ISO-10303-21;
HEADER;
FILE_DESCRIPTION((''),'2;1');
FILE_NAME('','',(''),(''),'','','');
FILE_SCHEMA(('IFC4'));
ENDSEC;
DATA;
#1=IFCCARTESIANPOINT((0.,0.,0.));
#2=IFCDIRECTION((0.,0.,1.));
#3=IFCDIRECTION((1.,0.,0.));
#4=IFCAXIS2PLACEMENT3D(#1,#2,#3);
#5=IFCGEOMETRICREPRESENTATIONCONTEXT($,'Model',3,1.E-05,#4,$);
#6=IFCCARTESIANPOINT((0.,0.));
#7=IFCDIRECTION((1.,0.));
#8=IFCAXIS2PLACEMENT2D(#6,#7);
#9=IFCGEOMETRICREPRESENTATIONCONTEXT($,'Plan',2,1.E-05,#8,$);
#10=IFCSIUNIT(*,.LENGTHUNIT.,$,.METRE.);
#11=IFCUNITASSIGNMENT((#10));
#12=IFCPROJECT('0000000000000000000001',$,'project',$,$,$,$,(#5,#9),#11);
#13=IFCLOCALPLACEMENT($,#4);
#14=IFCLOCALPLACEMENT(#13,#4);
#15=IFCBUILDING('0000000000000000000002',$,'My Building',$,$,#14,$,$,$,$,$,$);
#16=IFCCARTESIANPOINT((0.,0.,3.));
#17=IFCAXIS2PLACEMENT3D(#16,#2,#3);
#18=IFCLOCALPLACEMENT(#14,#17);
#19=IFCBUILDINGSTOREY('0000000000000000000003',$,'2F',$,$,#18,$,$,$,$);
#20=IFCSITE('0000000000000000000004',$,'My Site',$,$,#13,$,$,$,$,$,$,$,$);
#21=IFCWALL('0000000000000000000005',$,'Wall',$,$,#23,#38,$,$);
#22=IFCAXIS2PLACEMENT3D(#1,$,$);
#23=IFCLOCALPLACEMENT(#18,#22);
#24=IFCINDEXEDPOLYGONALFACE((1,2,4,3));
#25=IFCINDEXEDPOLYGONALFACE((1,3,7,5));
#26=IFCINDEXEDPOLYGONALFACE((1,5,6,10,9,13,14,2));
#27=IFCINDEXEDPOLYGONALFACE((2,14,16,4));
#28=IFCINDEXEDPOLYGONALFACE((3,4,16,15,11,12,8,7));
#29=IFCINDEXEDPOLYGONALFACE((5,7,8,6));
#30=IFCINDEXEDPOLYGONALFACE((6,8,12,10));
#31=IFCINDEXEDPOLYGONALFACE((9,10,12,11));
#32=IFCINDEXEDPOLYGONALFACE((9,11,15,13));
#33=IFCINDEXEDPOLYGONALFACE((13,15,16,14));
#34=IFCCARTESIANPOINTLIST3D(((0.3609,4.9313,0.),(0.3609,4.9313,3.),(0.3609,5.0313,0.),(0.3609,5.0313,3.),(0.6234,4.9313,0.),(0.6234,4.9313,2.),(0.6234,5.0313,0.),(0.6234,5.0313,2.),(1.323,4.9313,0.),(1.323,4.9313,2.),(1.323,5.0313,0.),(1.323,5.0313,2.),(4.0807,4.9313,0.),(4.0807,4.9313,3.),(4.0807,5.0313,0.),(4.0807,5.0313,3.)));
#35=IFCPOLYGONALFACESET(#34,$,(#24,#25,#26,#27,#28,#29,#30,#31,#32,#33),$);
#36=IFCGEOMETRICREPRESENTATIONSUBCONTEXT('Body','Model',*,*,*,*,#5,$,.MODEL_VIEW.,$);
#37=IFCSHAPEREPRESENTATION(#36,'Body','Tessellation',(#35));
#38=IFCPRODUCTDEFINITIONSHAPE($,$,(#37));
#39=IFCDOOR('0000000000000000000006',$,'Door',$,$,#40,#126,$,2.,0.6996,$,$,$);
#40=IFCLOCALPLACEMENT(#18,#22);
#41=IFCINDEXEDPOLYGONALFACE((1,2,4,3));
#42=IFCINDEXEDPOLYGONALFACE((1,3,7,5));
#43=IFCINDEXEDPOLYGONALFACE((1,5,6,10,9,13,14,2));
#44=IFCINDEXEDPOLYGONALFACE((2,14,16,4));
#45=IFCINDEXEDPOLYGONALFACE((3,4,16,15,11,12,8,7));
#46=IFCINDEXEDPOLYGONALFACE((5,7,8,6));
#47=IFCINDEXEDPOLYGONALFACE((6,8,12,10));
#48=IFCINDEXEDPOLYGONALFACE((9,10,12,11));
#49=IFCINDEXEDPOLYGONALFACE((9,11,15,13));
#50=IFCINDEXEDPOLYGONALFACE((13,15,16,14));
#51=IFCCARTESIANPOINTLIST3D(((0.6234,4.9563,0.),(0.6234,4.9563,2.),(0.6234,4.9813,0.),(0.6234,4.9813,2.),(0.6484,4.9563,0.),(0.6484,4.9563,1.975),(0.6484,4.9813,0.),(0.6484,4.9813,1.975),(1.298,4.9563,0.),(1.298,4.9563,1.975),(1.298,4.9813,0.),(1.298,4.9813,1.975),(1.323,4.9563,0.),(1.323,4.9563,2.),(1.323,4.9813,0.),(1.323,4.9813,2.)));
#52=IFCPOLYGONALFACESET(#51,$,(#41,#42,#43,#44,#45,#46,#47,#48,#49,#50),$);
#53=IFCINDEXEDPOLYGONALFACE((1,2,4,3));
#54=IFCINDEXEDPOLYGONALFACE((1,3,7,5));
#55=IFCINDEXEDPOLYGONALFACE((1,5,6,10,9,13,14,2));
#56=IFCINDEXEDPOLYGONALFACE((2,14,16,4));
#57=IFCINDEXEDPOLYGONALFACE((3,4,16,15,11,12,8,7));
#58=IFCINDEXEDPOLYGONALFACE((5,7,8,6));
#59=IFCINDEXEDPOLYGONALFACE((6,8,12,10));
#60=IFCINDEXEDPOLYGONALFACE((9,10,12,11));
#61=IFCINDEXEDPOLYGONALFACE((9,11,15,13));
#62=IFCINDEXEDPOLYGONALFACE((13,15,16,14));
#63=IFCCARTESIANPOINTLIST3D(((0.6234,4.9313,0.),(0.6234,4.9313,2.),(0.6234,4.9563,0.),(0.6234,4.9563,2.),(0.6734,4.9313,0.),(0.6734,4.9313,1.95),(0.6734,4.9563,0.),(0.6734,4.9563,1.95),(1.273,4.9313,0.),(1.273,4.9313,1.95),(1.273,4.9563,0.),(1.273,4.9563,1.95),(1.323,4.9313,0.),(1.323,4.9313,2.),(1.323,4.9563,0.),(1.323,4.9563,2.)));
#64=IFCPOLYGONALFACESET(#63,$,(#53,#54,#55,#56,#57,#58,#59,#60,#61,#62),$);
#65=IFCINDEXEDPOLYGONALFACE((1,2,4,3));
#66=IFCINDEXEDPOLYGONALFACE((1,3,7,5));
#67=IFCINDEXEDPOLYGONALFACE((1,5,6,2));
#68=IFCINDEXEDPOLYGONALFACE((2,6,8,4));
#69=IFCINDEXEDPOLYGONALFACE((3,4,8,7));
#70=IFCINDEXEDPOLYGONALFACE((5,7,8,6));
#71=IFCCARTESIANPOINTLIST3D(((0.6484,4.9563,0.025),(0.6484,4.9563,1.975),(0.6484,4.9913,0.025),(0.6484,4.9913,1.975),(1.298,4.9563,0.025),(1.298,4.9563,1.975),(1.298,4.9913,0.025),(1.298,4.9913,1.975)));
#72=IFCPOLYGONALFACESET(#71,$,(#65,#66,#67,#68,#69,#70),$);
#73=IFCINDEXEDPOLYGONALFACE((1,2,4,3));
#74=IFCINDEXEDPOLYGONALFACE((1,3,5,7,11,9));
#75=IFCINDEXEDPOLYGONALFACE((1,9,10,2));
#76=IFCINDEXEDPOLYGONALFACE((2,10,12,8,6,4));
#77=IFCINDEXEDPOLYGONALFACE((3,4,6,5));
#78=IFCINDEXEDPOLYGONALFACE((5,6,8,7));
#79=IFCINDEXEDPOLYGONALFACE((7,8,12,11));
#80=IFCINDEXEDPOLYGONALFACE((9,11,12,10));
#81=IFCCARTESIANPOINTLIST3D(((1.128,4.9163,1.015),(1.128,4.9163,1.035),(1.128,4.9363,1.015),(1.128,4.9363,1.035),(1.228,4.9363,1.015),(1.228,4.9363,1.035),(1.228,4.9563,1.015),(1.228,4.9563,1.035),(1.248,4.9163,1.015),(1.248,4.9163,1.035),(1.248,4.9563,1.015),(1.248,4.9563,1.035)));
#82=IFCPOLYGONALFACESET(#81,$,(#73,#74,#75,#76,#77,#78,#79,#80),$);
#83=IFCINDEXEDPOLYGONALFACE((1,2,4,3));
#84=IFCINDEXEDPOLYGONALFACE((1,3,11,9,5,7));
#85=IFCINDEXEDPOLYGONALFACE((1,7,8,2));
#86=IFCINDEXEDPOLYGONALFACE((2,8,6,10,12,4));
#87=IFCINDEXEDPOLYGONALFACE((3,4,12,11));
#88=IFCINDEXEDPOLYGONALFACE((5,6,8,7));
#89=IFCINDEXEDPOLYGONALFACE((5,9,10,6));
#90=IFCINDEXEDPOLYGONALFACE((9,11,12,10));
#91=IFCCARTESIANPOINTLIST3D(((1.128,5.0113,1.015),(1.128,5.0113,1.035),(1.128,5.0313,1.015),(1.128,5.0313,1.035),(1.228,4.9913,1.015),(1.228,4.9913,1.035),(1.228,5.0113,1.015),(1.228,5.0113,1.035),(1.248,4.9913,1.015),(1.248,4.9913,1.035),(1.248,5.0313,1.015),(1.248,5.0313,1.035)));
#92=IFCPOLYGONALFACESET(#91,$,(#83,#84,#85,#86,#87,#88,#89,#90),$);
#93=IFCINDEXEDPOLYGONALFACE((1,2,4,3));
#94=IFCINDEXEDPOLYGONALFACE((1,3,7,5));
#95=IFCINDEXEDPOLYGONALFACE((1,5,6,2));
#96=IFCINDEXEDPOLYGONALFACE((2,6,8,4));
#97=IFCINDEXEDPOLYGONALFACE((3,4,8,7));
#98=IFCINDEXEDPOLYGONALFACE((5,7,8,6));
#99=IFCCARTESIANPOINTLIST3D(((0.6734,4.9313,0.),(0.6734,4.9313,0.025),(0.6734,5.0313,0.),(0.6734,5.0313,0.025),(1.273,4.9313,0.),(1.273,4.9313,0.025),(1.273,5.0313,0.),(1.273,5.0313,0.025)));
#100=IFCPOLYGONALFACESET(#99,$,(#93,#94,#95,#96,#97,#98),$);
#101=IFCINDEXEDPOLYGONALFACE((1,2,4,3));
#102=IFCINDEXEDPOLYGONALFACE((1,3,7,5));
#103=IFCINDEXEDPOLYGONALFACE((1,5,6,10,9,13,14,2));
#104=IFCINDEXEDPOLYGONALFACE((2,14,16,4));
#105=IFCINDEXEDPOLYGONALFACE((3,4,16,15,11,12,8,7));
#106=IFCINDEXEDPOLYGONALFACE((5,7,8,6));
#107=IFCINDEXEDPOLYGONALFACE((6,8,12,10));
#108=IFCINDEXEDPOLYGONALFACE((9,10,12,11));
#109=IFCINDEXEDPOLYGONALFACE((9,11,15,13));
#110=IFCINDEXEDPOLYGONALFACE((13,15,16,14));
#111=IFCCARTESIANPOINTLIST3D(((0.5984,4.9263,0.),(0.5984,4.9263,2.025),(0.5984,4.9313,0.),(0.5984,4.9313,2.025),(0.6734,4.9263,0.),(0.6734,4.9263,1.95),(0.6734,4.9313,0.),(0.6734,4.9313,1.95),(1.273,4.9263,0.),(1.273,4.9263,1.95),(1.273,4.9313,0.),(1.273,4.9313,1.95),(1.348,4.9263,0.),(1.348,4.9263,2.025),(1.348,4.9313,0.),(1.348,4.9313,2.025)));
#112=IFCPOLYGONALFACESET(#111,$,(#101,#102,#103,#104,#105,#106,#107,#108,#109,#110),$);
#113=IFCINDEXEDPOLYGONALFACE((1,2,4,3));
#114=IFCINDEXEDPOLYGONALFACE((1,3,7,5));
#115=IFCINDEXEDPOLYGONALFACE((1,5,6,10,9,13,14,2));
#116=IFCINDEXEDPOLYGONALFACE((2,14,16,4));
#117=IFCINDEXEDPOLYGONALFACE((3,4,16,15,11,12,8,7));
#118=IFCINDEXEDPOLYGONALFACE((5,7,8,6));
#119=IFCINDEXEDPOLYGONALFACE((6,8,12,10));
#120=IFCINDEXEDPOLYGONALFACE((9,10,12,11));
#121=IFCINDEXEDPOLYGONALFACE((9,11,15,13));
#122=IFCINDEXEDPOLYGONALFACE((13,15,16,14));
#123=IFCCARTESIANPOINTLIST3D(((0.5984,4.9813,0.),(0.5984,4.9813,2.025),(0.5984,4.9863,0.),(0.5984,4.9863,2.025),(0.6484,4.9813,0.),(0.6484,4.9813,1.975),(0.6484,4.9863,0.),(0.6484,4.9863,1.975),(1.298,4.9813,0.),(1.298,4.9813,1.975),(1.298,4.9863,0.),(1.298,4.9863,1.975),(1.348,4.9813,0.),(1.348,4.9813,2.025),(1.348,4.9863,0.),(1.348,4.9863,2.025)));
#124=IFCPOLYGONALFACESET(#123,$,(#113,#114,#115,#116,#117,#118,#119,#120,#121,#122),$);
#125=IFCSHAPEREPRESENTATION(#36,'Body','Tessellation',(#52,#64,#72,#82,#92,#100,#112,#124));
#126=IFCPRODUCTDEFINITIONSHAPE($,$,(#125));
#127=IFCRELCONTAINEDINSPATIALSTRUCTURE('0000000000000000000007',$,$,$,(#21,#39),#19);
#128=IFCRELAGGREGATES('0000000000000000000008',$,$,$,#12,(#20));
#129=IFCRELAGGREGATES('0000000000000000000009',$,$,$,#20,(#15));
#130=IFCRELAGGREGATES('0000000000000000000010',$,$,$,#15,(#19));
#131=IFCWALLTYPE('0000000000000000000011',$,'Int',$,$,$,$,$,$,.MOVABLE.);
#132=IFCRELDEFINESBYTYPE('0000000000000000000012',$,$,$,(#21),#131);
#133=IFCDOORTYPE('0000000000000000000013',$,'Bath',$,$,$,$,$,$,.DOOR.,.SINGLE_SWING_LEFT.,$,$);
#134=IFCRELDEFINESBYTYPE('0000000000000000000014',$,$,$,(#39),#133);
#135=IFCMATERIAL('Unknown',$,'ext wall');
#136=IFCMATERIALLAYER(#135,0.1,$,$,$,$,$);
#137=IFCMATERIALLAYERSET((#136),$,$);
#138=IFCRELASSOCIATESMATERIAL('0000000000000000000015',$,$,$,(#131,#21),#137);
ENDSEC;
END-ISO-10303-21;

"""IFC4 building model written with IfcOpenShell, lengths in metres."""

from ifc_helpers import new_model, entity, si_unit, frame, origin_with_axes, origin_2d_with_axis, place, context, subcontext, project, spatial, line, indexed_curve, outline, extrude, shape, source, transform, mapped, material, layer, layer_set, layer_usage, type_object, type_shapes, element, fill, save


model = new_model("IFC4")

# Units and contexts
model_context = context("Model", 3, precision=1e-05, world=origin_with_axes())
plan_context = context("Plan", 2, precision=1e-05, world=origin_2d_with_axis())
body_context_1 = subcontext(model_context, "Body", "Model", "MODEL_VIEW")
body_context_2 = subcontext(plan_context, "Body", "Plan", "PLAN_VIEW")
ifc_project = project(units=[si_unit("LENGTHUNIT", "METRE")], contexts=[model_context, plan_context])

# Site, building, storey
site_placement = place(None, origin_with_axes())
site = spatial("IfcSite", under=ifc_project, at=site_placement, Name="My Site")
building_placement = place(site_placement, origin_with_axes())
building = spatial("IfcBuilding", under=site, at=building_placement, Name="My Building")
storey_placement = place(building_placement, frame((0.0, 0.0, 3.0), z_axis=(0.0, 0.0, 1.0), x_axis=(1.0, 0.0, 0.0)))
storey = spatial("IfcBuildingStorey", under=building, at=storey_placement, Name="2F")

# Shared definitions
ifc_material = material(Name="Unknown", Category="ext wall")

# Shared definitions
ifc_layer_1 = layer(ifc_material, 0.1)
ifc_layer_set_1 = layer_set([ifc_layer_1])
wall_type_1 = type_object("IfcWallType", Name="Int", PredefinedType="MOVABLE", material=ifc_layer_set_1)

# Wall, opening, door
ifc_layer_usage_1 = layer_usage(ifc_layer_set_1, "AXIS2", "POSITIVE", 0.0)
wall_1_placement = place(storey_placement, frame((4.0807, 5.0313, 0.0), z_axis=(0.0, 0.0, 1.0), x_axis=(-1.0, 0.0, 0.0)))
wall_1 = element("IfcWall", 1, at=wall_1_placement, inside=storey, type_object=wall_type_1, material=ifc_layer_usage_1, Name="Wall", context=body_context_1, shape_type="SweptSolid", body=[
    extrude(outline(indexed_curve([(0.0, 0.0), (0.0, 0.1), (3.7198, 0.1), (3.7198, 0.0)], segments=[line(1, 2, 3, 4, 1)])), origin_with_axes(), (0.0, 0.0, 1.0), 3.0),
])
shared_shape_1 = source(origin_with_axes(), body_context_1, "Body", "SweptSolid", [
    extrude(outline(indexed_curve([(0.0, 0.0), (0.6996, 0.0), (0.6996, 2.0), (0.0, 2.0)], segments=[line(1, 2, 3, 4, 1)])), frame((0.0, -0.6, 0.0), z_axis=(0.0, -1.0, 0.0), x_axis=(1.0, 0.0, 0.0)), (0.0, 0.0, -1.0), 1.2),
])
opening_1_placement = place(wall_1_placement, frame((3.4573, 0.1, 0.0), z_axis=(0.0, 0.0, 1.0), x_axis=(-1.0, 0.0, 0.0)))
opening_1 = element("IfcOpeningElement", 2, at=opening_1_placement, cuts=wall_1, PredefinedType="OPENING", context=body_context_1, shape_type="MappedRepresentation", body=[
    mapped(shared_shape_1, transform((0.0, 0.0, 0.0), x_axis=(1.0, 0.0, 0.0), y_axis=(0.0, 1.0, 0.0), z_axis=(0.0, 0.0, 1.0), scale=1.0)),
])
door_type_1 = type_object("IfcDoorType", Name="Bath", OperationType="SINGLE_SWING_LEFT", PredefinedType="DOOR")
shared_shape_2 = source(origin_with_axes(), body_context_1, "Body", "SweptSolid", [
    extrude(outline(indexed_curve([(0.0, 0.0), (0.0, 2.0), (0.6996, 2.0), (0.6996, 0.0), (0.6746, 0.0), (0.6746, 1.975), (0.025, 1.975), (0.025, 0.0)], segments=[line(1, 2, 3, 4, 5, 6, 7, 8, 1)])), frame((0.0, 0.025, 0.0), z_axis=(0.0, -1.0, 0.0), x_axis=(1.0, 0.0, 0.0)), (0.0, 0.0, -1.0), 0.025),
    extrude(outline(indexed_curve([(0.0, 0.0), (0.0, 2.0), (0.6996, 2.0), (0.6996, 0.0), (0.6496, 0.0), (0.6496, 1.95), (0.05, 1.95), (0.05, 0.0)], segments=[line(1, 2, 3, 4, 5, 6, 7, 8, 1)])), frame((0.0, 0.0, 0.0), z_axis=(0.0, -1.0, 0.0), x_axis=(1.0, 0.0, 0.0)), (0.0, 0.0, -1.0), 0.025),
    extrude(outline(indexed_curve([(0.0, 0.0), (0.6496, 0.0), (0.6496, 0.035), (0.0, 0.035)], segments=[line(1, 2, 3, 4, 1)])), frame((0.025, 0.025, 0.025), z_axis=(0.0, 0.0, 1.0), x_axis=(1.0, 0.0, 0.0)), (0.0, 0.0, 1.0), 1.95),
    extrude(outline(indexed_curve([(0.0, 0.0), (0.0, -0.04), (-0.12, -0.04), (-0.12, -0.02), (-0.02, -0.02), (-0.02, 0.0)], segments=[line(1, 2, 3, 4, 5, 6, 1)])), frame((0.6246, 0.025, 1.015), z_axis=(0.0, 0.0, 1.0), x_axis=(1.0, 0.0, 0.0)), (0.0, 0.0, 1.0), 0.02),
    extrude(outline(indexed_curve([(0.0, 0.0), (0.0, 0.04), (-0.12, 0.04), (-0.12, 0.02), (-0.02, 0.02), (-0.02, 0.0)], segments=[line(1, 2, 3, 4, 5, 6, 1)])), frame((0.6246, 0.06, 1.015), z_axis=(0.0, 0.0, 1.0), x_axis=(1.0, 0.0, 0.0)), (0.0, 0.0, 1.0), 0.02),
    extrude(outline(indexed_curve([(0.0, 0.0), (0.5996, 0.0), (0.5996, 0.1), (0.0, 0.1)], segments=[line(1, 2, 3, 4, 1)])), frame((0.05, 0.0, 0.0), z_axis=(0.0, 0.0, 1.0), x_axis=(1.0, 0.0, 0.0)), (0.0, 0.0, 1.0), 0.025),
    extrude(outline(indexed_curve([(0.0, 0.0), (0.0, 2.025), (0.7496, 2.025), (0.7496, 0.0), (0.6746, 0.0), (0.6746, 1.95), (0.075, 1.95), (0.075, 0.0)], segments=[line(1, 2, 3, 4, 5, 6, 7, 8, 1)])), frame((-0.025, -0.005, 0.0), z_axis=(0.0, -1.0, 0.0), x_axis=(1.0, 0.0, 0.0)), (0.0, 0.0, -1.0), 0.005),
    extrude(outline(indexed_curve([(0.0, 0.0), (0.0, 2.025), (0.7496, 2.025), (0.7496, 0.0), (0.6996, 0.0), (0.6996, 1.975), (0.05, 1.975), (0.05, 0.0)], segments=[line(1, 2, 3, 4, 5, 6, 7, 8, 1)])), frame((-0.025, 0.05, 0.0), z_axis=(0.0, -1.0, 0.0), x_axis=(1.0, 0.0, 0.0)), (0.0, 0.0, -1.0), 0.005),
])
shared_shape_3 = source(origin_with_axes(), body_context_2, "Body", "Curve2D", [
    entity("IfcIndexedPolyCurve", entity("IfcCartesianPointList2D", [[0.0, 0.0], [0.0, 0.05], [0.025, 0.05], [0.025, 0.025], [0.05, 0.025], [0.05, 0.0]]), [entity("IfcLineIndex", [1, 2, 3, 4, 5, 6, 1])]),
    entity("IfcIndexedPolyCurve", entity("IfcCartesianPointList2D", [[0.6996, 0.0], [0.6996, 0.05], [0.6746, 0.05], [0.6746, 0.025], [0.6496, 0.025], [0.6496, 0.0]]), [entity("IfcLineIndex", [1, 2, 3, 4, 5, 6, 1])]),
    entity("IfcTrimmedCurve", entity("IfcEllipse", entity("IfcAxis2Placement2D", entity("IfcCartesianPoint", [0.06, 0.05]), entity("IfcDirection", [1.0, 0.0])), 0.6146, 0.6496), [entity("IfcCartesianPoint", [0.6746, 0.05])], [entity("IfcCartesianPoint", [0.06, 0.6996])], True, "CARTESIAN"),
    entity("IfcIndexedPolyCurve", entity("IfcCartesianPointList2D", [[0.025, 0.05], [0.06, 0.05], [0.06, 0.6996], [0.025, 0.6996]]), [entity("IfcLineIndex", [1, 2, 3, 4, 1])]),
])
type_shapes(door_type_1, [shared_shape_2, shared_shape_3])
door_1_placement = place(opening_1_placement, frame((0.0, 0.0, 0.0), z_axis=(0.0, 0.0, 1.0), x_axis=(1.0, 0.0, 0.0)))
door_1 = element("IfcDoor", 3, at=door_1_placement, inside=storey, type_object=door_type_1, Name="Door", OverallHeight=2.0, OverallWidth=0.6996, shapes=[
    shape(body_context_1, "Body", "MappedRepresentation", [mapped(shared_shape_2, transform((0.0, 0.0, 0.0), x_axis=(1.0, 0.0, 0.0), y_axis=(0.0, 1.0, 0.0), z_axis=(0.0, 0.0, 1.0), scale=1.0))]),
    shape(body_context_2, "Body", "MappedRepresentation", [mapped(shared_shape_3, transform((0.0, 0.0, 0.0), x_axis=(1.0, 0.0, 0.0), y_axis=(0.0, 1.0, 0.0), z_axis=(0.0, 0.0, 1.0), scale=1.0))]),
])
fill(opening_1, door_1)

save(model, "model.ifc")
